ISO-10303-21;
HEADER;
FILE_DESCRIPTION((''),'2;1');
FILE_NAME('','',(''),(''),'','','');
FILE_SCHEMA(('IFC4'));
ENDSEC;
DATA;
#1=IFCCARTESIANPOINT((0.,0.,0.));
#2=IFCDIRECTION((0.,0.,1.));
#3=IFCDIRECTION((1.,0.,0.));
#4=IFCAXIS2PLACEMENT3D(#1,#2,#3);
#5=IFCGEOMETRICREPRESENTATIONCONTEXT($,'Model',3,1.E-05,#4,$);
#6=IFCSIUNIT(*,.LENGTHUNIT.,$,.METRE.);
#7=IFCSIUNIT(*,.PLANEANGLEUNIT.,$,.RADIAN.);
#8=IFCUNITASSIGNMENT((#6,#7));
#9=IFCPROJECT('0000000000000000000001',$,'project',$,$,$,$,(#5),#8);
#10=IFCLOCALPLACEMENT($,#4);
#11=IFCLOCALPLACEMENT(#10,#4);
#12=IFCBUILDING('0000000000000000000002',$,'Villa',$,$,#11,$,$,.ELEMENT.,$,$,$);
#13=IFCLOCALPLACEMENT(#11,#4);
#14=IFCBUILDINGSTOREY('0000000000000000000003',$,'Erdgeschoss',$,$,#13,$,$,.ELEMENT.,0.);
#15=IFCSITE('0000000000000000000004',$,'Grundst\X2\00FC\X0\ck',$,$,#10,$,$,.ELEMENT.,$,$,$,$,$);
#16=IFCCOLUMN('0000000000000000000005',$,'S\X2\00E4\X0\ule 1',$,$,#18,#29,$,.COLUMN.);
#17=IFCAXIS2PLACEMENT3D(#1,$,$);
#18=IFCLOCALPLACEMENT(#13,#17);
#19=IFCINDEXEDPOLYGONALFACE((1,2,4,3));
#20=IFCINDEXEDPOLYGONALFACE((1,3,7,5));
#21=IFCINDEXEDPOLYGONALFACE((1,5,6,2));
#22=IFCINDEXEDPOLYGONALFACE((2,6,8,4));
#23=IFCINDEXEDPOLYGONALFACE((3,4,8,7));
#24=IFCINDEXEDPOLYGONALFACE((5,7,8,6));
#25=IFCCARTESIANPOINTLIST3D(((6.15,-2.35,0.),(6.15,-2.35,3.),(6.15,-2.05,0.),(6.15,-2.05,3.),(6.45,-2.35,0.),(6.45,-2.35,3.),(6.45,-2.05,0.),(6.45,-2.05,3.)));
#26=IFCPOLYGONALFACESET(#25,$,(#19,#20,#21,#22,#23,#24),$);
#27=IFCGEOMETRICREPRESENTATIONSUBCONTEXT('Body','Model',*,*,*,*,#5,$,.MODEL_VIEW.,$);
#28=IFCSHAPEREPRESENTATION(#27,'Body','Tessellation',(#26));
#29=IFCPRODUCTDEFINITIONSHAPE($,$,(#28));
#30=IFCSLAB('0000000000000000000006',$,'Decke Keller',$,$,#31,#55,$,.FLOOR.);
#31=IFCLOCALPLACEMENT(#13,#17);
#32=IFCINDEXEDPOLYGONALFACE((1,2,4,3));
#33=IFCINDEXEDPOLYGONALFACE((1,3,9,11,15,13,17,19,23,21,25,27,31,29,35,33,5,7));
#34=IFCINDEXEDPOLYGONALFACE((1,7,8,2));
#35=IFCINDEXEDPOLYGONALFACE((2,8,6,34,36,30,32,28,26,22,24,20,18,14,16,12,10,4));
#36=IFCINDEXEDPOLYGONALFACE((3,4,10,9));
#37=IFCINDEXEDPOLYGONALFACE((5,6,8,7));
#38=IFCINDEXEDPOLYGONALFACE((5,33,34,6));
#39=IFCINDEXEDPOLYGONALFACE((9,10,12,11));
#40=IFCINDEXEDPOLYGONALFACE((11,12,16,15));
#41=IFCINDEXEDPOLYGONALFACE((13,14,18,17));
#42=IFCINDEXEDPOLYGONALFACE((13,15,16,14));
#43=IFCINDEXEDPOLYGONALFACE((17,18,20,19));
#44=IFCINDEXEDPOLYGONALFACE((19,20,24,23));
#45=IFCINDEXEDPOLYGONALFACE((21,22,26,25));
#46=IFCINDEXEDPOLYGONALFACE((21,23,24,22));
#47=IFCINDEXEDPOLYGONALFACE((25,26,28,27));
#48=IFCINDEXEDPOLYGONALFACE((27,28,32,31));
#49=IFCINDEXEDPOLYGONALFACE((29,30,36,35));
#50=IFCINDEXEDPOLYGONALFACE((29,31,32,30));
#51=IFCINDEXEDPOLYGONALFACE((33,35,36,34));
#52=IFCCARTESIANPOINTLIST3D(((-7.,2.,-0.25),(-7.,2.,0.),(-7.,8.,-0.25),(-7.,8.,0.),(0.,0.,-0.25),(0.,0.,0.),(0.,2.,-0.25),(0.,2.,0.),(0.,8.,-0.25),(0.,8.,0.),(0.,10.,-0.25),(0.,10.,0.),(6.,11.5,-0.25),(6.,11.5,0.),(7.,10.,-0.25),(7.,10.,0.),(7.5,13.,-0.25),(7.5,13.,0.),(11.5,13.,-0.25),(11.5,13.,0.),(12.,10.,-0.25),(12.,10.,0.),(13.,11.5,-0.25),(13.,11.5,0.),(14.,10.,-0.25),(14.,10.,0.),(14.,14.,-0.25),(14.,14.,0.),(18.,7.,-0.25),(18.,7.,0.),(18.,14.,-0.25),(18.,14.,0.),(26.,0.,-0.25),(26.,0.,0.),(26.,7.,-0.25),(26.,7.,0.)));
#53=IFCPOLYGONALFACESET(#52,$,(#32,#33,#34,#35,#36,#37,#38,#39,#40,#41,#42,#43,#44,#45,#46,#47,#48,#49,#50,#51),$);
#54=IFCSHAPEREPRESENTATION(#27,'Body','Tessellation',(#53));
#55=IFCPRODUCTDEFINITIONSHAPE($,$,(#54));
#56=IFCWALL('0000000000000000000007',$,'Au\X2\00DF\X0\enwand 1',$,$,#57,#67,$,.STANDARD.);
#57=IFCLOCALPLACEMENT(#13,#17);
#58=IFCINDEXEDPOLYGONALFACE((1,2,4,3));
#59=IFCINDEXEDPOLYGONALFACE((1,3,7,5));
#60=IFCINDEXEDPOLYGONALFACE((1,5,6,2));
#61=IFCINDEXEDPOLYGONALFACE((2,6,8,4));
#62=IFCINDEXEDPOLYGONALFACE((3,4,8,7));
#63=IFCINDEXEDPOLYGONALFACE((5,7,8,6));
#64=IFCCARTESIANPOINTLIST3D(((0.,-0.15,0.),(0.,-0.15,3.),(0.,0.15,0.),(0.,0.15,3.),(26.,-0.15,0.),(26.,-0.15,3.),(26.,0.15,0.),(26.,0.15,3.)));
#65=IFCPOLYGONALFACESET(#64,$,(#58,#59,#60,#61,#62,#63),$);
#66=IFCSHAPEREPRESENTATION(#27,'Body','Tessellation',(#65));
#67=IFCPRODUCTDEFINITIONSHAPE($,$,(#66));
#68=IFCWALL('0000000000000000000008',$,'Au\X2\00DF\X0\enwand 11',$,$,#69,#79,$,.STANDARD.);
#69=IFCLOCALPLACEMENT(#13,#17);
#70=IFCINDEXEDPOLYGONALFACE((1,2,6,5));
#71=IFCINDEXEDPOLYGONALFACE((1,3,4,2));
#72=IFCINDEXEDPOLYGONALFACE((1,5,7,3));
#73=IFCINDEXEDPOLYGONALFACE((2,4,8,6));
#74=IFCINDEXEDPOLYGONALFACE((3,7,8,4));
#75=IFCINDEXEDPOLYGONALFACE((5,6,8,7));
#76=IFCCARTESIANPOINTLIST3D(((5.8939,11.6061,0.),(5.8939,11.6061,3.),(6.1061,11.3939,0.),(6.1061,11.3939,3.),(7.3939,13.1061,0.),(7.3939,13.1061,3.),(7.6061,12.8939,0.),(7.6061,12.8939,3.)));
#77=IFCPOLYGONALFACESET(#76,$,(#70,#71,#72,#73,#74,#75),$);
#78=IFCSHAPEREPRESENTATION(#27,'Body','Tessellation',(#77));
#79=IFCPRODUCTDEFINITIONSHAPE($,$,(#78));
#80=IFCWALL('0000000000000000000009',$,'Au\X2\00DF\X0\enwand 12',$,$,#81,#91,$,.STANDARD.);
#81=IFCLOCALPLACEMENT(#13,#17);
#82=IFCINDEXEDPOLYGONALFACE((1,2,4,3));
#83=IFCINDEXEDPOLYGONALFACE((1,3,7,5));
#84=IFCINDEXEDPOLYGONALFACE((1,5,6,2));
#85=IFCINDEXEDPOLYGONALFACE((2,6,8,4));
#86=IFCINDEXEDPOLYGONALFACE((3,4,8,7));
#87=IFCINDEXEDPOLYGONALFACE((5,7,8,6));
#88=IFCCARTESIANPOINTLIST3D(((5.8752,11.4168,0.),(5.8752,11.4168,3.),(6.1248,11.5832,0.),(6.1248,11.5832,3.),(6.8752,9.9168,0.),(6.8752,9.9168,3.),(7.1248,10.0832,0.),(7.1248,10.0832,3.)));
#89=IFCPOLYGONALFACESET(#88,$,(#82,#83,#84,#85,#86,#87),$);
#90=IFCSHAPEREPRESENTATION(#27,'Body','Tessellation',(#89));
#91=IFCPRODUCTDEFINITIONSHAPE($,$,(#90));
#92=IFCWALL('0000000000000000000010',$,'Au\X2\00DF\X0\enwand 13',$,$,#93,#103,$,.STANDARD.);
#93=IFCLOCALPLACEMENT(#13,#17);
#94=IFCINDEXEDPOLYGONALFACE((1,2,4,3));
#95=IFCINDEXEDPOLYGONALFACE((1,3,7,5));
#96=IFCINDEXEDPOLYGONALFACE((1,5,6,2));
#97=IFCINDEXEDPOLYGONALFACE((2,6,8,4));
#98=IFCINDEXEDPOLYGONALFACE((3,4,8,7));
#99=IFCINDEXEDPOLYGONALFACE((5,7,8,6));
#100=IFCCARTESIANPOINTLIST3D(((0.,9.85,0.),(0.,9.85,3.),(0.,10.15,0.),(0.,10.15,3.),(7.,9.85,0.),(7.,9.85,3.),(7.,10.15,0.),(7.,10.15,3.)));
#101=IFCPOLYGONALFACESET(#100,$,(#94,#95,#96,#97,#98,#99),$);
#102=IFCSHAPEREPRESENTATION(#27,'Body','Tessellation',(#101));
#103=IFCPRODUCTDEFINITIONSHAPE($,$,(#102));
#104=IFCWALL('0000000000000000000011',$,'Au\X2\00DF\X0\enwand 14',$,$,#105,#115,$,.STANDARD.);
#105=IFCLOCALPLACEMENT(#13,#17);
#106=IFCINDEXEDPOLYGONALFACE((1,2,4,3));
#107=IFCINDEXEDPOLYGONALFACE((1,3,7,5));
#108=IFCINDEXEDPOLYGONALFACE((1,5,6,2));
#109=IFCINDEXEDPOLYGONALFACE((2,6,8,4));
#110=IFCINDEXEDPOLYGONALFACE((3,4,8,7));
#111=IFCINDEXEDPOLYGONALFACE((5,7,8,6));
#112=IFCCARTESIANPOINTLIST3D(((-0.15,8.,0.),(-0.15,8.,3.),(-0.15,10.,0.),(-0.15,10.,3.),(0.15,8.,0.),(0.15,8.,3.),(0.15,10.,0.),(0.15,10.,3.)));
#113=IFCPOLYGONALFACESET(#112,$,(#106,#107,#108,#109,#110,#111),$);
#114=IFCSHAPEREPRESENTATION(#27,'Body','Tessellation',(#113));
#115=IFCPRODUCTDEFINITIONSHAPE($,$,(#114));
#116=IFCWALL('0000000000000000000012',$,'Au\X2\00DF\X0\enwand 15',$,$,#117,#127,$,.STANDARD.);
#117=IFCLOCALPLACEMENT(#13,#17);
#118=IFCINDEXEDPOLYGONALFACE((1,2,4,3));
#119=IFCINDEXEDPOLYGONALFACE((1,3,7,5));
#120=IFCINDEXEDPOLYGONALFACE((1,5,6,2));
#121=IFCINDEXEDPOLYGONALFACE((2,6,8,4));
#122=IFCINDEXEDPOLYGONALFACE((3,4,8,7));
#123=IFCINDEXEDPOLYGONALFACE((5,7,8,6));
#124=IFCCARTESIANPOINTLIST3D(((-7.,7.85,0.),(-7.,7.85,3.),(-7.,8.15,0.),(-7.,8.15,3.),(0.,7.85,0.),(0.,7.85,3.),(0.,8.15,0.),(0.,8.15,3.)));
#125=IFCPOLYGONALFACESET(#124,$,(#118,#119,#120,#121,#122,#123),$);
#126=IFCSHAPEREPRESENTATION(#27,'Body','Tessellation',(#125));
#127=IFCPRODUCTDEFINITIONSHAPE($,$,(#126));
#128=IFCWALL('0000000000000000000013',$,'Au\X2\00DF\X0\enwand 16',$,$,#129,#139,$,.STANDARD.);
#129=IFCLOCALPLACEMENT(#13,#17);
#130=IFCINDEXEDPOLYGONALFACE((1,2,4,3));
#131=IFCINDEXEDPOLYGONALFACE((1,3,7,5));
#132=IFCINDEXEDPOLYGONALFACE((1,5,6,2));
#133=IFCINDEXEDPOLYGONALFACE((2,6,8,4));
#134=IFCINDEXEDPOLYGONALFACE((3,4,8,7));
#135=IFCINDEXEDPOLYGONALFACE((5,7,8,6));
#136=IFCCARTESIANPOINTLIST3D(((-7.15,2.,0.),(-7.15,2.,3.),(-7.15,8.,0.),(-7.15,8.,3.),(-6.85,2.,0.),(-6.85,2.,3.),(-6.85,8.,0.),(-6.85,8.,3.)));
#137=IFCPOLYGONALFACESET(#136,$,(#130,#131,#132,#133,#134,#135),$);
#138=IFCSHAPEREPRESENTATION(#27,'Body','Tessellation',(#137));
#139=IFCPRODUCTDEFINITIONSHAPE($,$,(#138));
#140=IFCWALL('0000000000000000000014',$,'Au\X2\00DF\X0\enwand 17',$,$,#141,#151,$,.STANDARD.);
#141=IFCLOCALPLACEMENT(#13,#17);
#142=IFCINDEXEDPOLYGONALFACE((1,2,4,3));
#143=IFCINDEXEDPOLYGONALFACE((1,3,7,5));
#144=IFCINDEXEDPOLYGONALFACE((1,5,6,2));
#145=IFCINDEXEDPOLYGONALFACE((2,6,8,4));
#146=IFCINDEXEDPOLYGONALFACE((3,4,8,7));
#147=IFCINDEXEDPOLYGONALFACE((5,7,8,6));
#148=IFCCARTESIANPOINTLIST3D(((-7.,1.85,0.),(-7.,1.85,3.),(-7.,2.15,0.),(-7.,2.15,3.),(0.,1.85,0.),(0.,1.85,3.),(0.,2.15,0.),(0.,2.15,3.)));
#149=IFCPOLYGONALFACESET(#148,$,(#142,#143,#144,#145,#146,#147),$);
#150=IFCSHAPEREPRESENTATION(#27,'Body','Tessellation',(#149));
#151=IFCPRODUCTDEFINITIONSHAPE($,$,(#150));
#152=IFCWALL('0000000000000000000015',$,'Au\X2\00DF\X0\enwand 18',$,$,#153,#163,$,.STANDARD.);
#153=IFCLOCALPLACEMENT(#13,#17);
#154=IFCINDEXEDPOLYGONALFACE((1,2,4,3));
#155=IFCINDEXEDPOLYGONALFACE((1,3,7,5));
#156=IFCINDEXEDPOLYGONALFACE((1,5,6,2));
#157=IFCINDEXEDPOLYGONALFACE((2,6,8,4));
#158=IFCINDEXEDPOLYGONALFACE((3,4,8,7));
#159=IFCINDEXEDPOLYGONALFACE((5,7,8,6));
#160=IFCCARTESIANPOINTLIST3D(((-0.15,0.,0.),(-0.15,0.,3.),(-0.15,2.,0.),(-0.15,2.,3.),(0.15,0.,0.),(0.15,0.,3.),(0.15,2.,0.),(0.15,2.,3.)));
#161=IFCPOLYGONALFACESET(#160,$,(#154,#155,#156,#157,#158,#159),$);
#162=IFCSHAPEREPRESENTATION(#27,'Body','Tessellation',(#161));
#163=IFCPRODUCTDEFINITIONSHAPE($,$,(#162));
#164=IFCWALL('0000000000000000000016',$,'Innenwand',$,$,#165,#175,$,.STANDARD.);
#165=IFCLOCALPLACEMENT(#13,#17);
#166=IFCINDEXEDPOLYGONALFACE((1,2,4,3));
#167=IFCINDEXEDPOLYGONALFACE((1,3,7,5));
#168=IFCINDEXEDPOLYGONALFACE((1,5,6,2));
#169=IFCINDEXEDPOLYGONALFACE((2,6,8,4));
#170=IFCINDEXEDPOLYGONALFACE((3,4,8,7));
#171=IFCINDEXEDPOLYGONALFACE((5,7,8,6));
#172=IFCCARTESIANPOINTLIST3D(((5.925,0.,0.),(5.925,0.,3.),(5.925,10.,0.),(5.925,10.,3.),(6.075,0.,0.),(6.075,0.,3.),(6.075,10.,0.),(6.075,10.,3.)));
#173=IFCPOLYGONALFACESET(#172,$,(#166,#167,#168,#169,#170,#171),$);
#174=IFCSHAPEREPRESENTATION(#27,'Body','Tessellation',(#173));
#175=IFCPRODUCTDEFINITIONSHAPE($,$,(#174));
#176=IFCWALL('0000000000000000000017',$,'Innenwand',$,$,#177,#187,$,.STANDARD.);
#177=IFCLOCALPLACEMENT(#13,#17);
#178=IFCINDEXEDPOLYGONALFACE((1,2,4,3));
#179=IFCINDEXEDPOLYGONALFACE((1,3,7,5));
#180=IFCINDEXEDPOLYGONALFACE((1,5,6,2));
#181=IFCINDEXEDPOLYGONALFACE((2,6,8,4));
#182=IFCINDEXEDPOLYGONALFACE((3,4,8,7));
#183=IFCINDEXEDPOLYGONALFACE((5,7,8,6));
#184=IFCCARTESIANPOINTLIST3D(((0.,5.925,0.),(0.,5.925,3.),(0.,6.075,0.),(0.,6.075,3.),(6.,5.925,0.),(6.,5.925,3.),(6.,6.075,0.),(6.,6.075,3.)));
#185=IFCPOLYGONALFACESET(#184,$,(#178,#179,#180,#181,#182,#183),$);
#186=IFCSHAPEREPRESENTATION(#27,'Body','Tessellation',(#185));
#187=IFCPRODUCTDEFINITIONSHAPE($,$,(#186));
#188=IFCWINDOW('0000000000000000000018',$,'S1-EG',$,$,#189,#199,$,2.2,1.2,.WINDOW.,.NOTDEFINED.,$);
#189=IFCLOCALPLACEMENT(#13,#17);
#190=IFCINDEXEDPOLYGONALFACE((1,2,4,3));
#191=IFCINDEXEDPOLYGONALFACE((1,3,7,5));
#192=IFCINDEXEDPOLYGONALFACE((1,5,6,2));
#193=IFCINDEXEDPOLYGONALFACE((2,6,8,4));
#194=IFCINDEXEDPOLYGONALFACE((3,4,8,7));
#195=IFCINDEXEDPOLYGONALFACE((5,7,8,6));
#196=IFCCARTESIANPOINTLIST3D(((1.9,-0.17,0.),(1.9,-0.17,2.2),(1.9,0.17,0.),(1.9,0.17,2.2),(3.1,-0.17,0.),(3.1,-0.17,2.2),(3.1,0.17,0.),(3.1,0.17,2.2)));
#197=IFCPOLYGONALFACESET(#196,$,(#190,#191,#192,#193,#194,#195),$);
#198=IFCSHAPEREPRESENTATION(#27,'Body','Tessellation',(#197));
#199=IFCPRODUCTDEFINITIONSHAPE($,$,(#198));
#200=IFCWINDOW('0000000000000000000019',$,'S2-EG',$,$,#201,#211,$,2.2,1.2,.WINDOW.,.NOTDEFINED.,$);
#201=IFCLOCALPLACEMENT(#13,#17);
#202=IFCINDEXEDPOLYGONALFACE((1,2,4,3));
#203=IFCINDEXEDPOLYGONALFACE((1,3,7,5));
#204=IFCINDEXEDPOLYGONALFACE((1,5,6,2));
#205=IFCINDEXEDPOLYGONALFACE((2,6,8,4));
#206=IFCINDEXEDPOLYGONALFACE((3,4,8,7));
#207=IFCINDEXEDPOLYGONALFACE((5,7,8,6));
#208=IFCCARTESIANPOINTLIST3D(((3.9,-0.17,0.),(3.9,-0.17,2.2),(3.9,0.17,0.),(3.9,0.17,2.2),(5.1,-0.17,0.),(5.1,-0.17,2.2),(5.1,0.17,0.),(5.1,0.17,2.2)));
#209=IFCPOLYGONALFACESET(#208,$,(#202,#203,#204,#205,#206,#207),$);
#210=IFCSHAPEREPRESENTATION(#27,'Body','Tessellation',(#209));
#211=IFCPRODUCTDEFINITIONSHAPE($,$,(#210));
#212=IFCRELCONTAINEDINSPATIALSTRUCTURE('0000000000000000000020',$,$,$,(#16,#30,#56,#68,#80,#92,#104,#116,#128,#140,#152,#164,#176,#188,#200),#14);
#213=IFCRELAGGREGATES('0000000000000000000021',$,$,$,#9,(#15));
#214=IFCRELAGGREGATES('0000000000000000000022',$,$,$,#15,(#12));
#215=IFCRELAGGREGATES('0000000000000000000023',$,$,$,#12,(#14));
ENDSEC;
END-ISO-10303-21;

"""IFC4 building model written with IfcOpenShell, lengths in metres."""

from ifc_helpers import new_model, si_unit, frame, frame_2d, origin_with_axes, origin_2d, place, context, subcontext, project, spatial, polyline, rectangle, outline, extrude, element, save


model = new_model("IFC4")

# Units and contexts
model_context = context("Model", 3, precision=1e-05, world=origin_with_axes())
body_context = subcontext(model_context, "Body", "Model", "MODEL_VIEW")
ifc_project = project(units=[si_unit("LENGTHUNIT", "METRE"), si_unit("PLANEANGLEUNIT", "RADIAN")], contexts=[model_context])

# Site, building, storey
site_placement = place(None, origin_with_axes())
site = spatial("IfcSite", under=ifc_project, at=site_placement, Name="Grundstück", CompositionType="ELEMENT")
building_placement = place(site_placement, origin_with_axes())
building = spatial("IfcBuilding", under=site, at=building_placement, Name="Villa", CompositionType="ELEMENT")
storey_placement = place(building_placement, origin_with_axes())
storey = spatial("IfcBuildingStorey", under=building, at=storey_placement, Name="Erdgeschoss", CompositionType="ELEMENT", Elevation=0.0)

# Column
column_placement = place(storey_placement, frame((6.3, -2.2, 0.0), z_axis=(0.0, 0.0, 1.0), x_axis=(1.0, 0.0, 0.0)))
element("IfcColumn", 1, at=column_placement, inside=storey, Name="Säule 1", PredefinedType="COLUMN", context=body_context, shape_type="SweptSolid", body=[
    extrude(rectangle(XDim=0.3, YDim=0.3, at=origin_2d()), origin_with_axes(), (0.0, 0.0, 1.0), 3.0),
])

# Slab
slab_placement = place(storey_placement, frame((0.0, 0.0, -0.25), z_axis=(0.0, 0.0, 1.0), x_axis=(1.0, 0.0, 0.0)))
element("IfcSlab", 2, at=slab_placement, inside=storey, Name="Decke Keller", PredefinedType="FLOOR", context=body_context, shape_type="SweptSolid", body=[
    extrude(outline(polyline([(0.0, 0.0), (26.0, 0.0), (26.0, 7.0), (18.0, 7.0), (18.0, 14.0), (14.0, 14.0), (14.0, 10.0), (12.0, 10.0), (13.0, 11.5), (11.5, 13.0), (7.5, 13.0), (6.0, 11.5), (7.0, 10.0), (0.0, 10.0), (0.0, 8.0), (-7.0, 8.0), (-7.0, 2.0), (0.0, 2.0), (0.0, 0.0)])), origin_with_axes(), (0.0, 0.0, 1.0), 0.25),
])

# Walls
wall_1_placement = place(storey_placement, origin_with_axes())
element("IfcWall", 3, at=wall_1_placement, inside=storey, Name="Außenwand 1", PredefinedType="STANDARD", context=body_context, shape_type="SweptSolid", body=[
    extrude(rectangle(XDim=26.0, YDim=0.3, at=frame_2d((13.0, 0.0))), origin_with_axes(), (0.0, 0.0, 1.0), 3.0),
])
wall_2_placement = place(storey_placement, frame((7.5, 13.0, 0.0), z_axis=(0.0, 0.0, 1.0), x_axis=(-0.707107, -0.707107, 0.0)))
element("IfcWall", 4, at=wall_2_placement, inside=storey, Name="Außenwand 11", PredefinedType="STANDARD", context=body_context, shape_type="SweptSolid", body=[
    extrude(rectangle(XDim=2.1213, YDim=0.3, at=frame_2d((1.0607, 0.0))), origin_with_axes(), (0.0, 0.0, 1.0), 3.0),
])
wall_3_placement = place(storey_placement, frame((6.0, 11.5, 0.0), z_axis=(0.0, 0.0, 1.0), x_axis=(0.5547, -0.83205, 0.0)))
element("IfcWall", 5, at=wall_3_placement, inside=storey, Name="Außenwand 12", PredefinedType="STANDARD", context=body_context, shape_type="SweptSolid", body=[
    extrude(rectangle(XDim=1.8028, YDim=0.3, at=frame_2d((0.9014, 0.0))), origin_with_axes(), (0.0, 0.0, 1.0), 3.0),
])
wall_4_placement = place(storey_placement, frame((7.0, 10.0, 0.0), z_axis=(0.0, 0.0, 1.0), x_axis=(-1.0, 0.0, 0.0)))
element("IfcWall", 6, at=wall_4_placement, inside=storey, Name="Außenwand 13", PredefinedType="STANDARD", context=body_context, shape_type="SweptSolid", body=[
    extrude(rectangle(XDim=7.0, YDim=0.3, at=frame_2d((3.5, 0.0))), origin_with_axes(), (0.0, 0.0, 1.0), 3.0),
])
wall_5_placement = place(storey_placement, frame((0.0, 10.0, 0.0), z_axis=(0.0, 0.0, 1.0), x_axis=(0.0, -1.0, 0.0)))
element("IfcWall", 7, at=wall_5_placement, inside=storey, Name="Außenwand 14", PredefinedType="STANDARD", context=body_context, shape_type="SweptSolid", body=[
    extrude(rectangle(XDim=2.0, YDim=0.3, at=frame_2d((1.0, 0.0))), origin_with_axes(), (0.0, 0.0, 1.0), 3.0),
])
wall_6_placement = place(storey_placement, frame((0.0, 8.0, 0.0), z_axis=(0.0, 0.0, 1.0), x_axis=(-1.0, 0.0, 0.0)))
element("IfcWall", 8, at=wall_6_placement, inside=storey, Name="Außenwand 15", PredefinedType="STANDARD", context=body_context, shape_type="SweptSolid", body=[
    extrude(rectangle(XDim=7.0, YDim=0.3, at=frame_2d((3.5, 0.0))), origin_with_axes(), (0.0, 0.0, 1.0), 3.0),
])
wall_7_placement = place(storey_placement, frame((-7.0, 8.0, 0.0), z_axis=(0.0, 0.0, 1.0), x_axis=(0.0, -1.0, 0.0)))
element("IfcWall", 9, at=wall_7_placement, inside=storey, Name="Außenwand 16", PredefinedType="STANDARD", context=body_context, shape_type="SweptSolid", body=[
    extrude(rectangle(XDim=6.0, YDim=0.3, at=frame_2d((3.0, 0.0))), origin_with_axes(), (0.0, 0.0, 1.0), 3.0),
])
wall_8_placement = place(storey_placement, frame((-7.0, 2.0, 0.0), z_axis=(0.0, 0.0, 1.0), x_axis=(1.0, 0.0, 0.0)))
element("IfcWall", 10, at=wall_8_placement, inside=storey, Name="Außenwand 17", PredefinedType="STANDARD", context=body_context, shape_type="SweptSolid", body=[
    extrude(rectangle(XDim=7.0, YDim=0.3, at=frame_2d((3.5, 0.0))), origin_with_axes(), (0.0, 0.0, 1.0), 3.0),
])
wall_9_placement = place(storey_placement, frame((0.0, 2.0, 0.0), z_axis=(0.0, 0.0, 1.0), x_axis=(0.0, -1.0, 0.0)))
element("IfcWall", 11, at=wall_9_placement, inside=storey, Name="Außenwand 18", PredefinedType="STANDARD", context=body_context, shape_type="SweptSolid", body=[
    extrude(rectangle(XDim=2.0, YDim=0.3, at=frame_2d((1.0, 0.0))), origin_with_axes(), (0.0, 0.0, 1.0), 3.0),
])
wall_10_placement = place(storey_placement, frame((6.0, 0.0, 0.0), z_axis=(0.0, 0.0, 1.0), x_axis=(0.0, 1.0, 0.0)))
element("IfcWall", 12, at=wall_10_placement, inside=storey, Name="Innenwand", PredefinedType="STANDARD", context=body_context, shape_type="SweptSolid", body=[
    extrude(rectangle(XDim=10.0, YDim=0.15, at=frame_2d((5.0, 0.0))), origin_with_axes(), (0.0, 0.0, 1.0), 3.0),
])
wall_11_placement = place(storey_placement, frame((0.0, 6.0, 0.0), z_axis=(0.0, 0.0, 1.0), x_axis=(1.0, 0.0, 0.0)))
element("IfcWall", 13, at=wall_11_placement, inside=storey, Name="Innenwand", PredefinedType="STANDARD", context=body_context, shape_type="SweptSolid", body=[
    extrude(rectangle(XDim=6.0, YDim=0.15, at=frame_2d((3.0, 0.0))), origin_with_axes(), (0.0, 0.0, 1.0), 3.0),
])

# Windows
for number, where, z_axis, x_axis, name in (
    (14, (2.5, 0.0, 0.0), (0.0, 0.0, 1.0), (1.0, 0.0, 0.0), "S1-EG"),
    (15, (4.5, 0.0, 0.0), (0.0, 0.0, 1.0), (1.0, 0.0, 0.0), "S2-EG"),
):
    element("IfcWindow", number, at=place(storey_placement, frame(where, z_axis=z_axis, x_axis=x_axis)), inside=storey, Name=name, OverallHeight=2.2, OverallWidth=1.2, PartitioningType="NOTDEFINED", PredefinedType="WINDOW", context=body_context, shape_type="SweptSolid", body=[
        extrude(rectangle(XDim=1.2, YDim=0.34, at=origin_2d()), origin_with_axes(), (0.0, 0.0, 1.0), 2.2),
    ])

save(model, "model.ifc")
